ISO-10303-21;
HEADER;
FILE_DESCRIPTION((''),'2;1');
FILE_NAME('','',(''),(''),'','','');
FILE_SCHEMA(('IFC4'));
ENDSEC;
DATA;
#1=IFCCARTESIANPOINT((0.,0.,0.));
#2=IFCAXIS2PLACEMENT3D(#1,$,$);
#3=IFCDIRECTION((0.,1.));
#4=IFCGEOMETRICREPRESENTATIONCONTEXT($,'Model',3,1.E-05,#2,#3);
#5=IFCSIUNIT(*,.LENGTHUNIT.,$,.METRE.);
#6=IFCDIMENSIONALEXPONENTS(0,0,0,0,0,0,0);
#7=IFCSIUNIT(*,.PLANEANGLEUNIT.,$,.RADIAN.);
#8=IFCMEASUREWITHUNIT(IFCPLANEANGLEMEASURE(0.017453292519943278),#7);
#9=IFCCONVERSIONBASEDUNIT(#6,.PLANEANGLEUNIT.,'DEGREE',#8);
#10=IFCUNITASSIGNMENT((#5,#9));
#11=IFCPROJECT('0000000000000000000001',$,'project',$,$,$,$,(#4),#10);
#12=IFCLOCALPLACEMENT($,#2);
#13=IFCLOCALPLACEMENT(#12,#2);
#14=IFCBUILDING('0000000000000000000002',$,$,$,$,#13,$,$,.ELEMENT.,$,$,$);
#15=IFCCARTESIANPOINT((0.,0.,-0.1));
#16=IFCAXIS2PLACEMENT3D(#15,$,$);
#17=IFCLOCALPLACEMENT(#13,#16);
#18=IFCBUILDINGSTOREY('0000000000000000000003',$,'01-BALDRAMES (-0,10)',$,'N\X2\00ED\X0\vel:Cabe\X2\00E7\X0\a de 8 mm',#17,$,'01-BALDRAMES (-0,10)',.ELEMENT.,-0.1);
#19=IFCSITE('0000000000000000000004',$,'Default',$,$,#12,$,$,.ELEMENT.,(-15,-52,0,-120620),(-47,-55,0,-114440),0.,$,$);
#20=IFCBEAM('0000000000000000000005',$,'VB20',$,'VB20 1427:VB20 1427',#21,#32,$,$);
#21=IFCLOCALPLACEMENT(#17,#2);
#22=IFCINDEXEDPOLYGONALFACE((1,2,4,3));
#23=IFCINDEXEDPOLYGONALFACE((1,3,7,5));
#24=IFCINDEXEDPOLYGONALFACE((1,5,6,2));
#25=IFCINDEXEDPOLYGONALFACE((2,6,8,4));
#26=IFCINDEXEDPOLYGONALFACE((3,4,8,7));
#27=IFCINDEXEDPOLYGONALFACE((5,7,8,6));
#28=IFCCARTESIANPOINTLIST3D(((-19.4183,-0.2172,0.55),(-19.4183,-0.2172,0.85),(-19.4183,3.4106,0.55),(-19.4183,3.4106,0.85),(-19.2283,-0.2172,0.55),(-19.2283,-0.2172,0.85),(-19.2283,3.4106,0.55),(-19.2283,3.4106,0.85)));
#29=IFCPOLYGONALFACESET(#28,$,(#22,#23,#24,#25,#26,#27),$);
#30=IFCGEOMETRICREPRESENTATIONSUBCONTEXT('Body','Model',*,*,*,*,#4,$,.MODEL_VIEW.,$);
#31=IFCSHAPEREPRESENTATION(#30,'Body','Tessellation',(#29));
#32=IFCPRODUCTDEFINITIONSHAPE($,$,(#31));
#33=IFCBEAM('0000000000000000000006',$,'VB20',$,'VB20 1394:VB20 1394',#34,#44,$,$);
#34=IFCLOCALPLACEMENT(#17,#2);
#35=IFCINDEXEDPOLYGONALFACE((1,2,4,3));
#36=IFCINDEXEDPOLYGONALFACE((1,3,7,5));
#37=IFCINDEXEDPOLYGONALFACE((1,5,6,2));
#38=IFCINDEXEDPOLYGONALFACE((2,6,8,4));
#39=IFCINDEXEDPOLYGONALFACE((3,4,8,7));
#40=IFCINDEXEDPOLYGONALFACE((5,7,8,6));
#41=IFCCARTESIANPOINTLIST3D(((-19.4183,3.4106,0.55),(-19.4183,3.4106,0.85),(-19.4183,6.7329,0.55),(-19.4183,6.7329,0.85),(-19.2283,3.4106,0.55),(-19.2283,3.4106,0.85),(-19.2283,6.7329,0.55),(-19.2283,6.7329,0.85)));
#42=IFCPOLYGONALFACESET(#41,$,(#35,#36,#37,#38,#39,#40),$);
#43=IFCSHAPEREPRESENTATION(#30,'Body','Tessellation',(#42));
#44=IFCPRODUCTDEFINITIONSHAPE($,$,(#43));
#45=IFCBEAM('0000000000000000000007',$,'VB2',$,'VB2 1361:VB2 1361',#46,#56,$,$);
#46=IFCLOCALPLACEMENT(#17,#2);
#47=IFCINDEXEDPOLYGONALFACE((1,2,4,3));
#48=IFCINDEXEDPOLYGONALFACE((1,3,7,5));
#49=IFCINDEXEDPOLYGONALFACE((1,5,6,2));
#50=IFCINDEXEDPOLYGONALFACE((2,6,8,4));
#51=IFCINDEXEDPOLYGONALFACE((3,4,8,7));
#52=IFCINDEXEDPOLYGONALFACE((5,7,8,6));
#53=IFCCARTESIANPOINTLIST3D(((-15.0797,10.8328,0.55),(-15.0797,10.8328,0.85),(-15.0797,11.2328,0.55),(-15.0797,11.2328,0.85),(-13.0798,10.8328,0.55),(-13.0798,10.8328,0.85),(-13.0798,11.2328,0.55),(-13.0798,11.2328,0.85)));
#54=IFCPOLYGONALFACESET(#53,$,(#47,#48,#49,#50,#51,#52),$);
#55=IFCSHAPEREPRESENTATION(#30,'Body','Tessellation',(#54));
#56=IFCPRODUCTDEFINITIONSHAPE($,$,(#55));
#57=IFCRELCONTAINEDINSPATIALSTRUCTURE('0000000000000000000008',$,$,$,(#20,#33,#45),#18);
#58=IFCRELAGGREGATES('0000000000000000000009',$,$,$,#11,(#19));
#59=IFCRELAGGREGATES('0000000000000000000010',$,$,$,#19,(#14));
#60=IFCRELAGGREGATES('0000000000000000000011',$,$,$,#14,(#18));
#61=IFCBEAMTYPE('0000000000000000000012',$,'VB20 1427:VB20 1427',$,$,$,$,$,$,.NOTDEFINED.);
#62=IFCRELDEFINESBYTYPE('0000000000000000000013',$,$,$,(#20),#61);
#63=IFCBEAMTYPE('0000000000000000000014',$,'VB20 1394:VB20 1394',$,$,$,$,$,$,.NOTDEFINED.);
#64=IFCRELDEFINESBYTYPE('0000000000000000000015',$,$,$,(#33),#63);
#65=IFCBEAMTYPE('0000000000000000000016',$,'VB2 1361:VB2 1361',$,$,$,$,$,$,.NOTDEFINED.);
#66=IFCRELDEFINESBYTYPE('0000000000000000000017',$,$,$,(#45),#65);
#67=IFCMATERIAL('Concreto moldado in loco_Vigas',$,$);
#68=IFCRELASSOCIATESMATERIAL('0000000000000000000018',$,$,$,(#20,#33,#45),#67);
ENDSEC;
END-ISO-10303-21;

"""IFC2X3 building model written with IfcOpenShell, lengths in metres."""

from ifc_helpers import new_model, entity, si_unit, converted_unit, direction, frame, frame_2d, origin, origin_2d_with_axis, place, context, subcontext, project, spatial, rectangle, extrude, material, type_object, element, save


model = new_model("IFC2X3")

# Units and contexts
model_context = context("Model", 3, precision=1e-05, world=origin(), true_north=direction((0.0, 1.0)))
body_context = subcontext(model_context, "Body", "Model", "MODEL_VIEW")
ifc_project = project(units=[si_unit("LENGTHUNIT", "METRE"), converted_unit("PLANEANGLEUNIT", "DEGREE", entity("IfcPlaneAngleMeasure", 0.017453292519943278), si_unit("PLANEANGLEUNIT", "RADIAN"), dimensions=[0, 0, 0, 0, 0, 0, 0])], contexts=[model_context])

# Site, building, storey
site_placement = place(None, origin())
site = spatial("IfcSite", under=ifc_project, at=site_placement, Name="Default", CompositionType="ELEMENT", RefLatitude=(-15, -52, 0, -120620), RefLongitude=(-47, -55, 0, -114440), RefElevation=0.0)
building_placement = place(site_placement, origin())
building = spatial("IfcBuilding", under=site, at=building_placement, CompositionType="ELEMENT")
storey_placement = place(building_placement, frame((0.0, 0.0, -0.1)))
storey = spatial("IfcBuildingStorey", under=building, at=storey_placement, Name="01-BALDRAMES (-0,10)", ObjectType="Nível:Cabeça de 8 mm", LongName="01-BALDRAMES (-0,10)", CompositionType="ELEMENT", Elevation=-0.1)

# Beams
ifc_material_1 = material(Name="Concreto moldado in loco_Vigas")
beam_type_1 = type_object("IfcBeamType", Name="VB20 1427:VB20 1427", PredefinedType="NOTDEFINED")
beam_1_placement = place(storey_placement, origin())
element("IfcBeam", 1, at=beam_1_placement, inside=storey, type_object=beam_type_1, material=ifc_material_1, Name="VB20", ObjectType="VB20 1427:VB20 1427", context=body_context, shape_type="SweptSolid", body=[
    extrude(rectangle(XDim=0.3, YDim=3.6278, at=frame_2d((0.0, 0.0), x_axis=(0.0, 1.0))), frame((-19.4183, 1.5967, 0.7), z_axis=(1.0, 0.0, 0.0), x_axis=(0.0, -1.0, 0.0)), (0.0, 0.0, 1.0), 0.19),
])
beam_type_2 = type_object("IfcBeamType", Name="VB20 1394:VB20 1394", PredefinedType="NOTDEFINED")
beam_2_placement = place(storey_placement, origin())
element("IfcBeam", 2, at=beam_2_placement, inside=storey, type_object=beam_type_2, material=ifc_material_1, Name="VB20", ObjectType="VB20 1394:VB20 1394", context=body_context, shape_type="SweptSolid", body=[
    extrude(rectangle(XDim=0.3, YDim=3.3223, at=frame_2d((0.0, 0.0), x_axis=(0.0, 1.0))), frame((-19.4183, 5.0718, 0.7), z_axis=(1.0, 0.0, 0.0), x_axis=(0.0, -1.0, 0.0)), (0.0, 0.0, 1.0), 0.19),
])
beam_type_3 = type_object("IfcBeamType", Name="VB2 1361:VB2 1361", PredefinedType="NOTDEFINED")
beam_3_placement = place(storey_placement, origin())
element("IfcBeam", 3, at=beam_3_placement, inside=storey, type_object=beam_type_3, material=ifc_material_1, Name="VB2", ObjectType="VB2 1361:VB2 1361", context=body_context, shape_type="SweptSolid", body=[
    extrude(rectangle(XDim=0.3, YDim=0.4, at=origin_2d_with_axis()), frame((-15.0797, 11.0328, 0.7), z_axis=(1.0, 0.0, 0.0), x_axis=(0.0, 0.0, -1.0)), (0.0, 0.0, 1.0), 1.9999),
])

save(model, "model.ifc")
